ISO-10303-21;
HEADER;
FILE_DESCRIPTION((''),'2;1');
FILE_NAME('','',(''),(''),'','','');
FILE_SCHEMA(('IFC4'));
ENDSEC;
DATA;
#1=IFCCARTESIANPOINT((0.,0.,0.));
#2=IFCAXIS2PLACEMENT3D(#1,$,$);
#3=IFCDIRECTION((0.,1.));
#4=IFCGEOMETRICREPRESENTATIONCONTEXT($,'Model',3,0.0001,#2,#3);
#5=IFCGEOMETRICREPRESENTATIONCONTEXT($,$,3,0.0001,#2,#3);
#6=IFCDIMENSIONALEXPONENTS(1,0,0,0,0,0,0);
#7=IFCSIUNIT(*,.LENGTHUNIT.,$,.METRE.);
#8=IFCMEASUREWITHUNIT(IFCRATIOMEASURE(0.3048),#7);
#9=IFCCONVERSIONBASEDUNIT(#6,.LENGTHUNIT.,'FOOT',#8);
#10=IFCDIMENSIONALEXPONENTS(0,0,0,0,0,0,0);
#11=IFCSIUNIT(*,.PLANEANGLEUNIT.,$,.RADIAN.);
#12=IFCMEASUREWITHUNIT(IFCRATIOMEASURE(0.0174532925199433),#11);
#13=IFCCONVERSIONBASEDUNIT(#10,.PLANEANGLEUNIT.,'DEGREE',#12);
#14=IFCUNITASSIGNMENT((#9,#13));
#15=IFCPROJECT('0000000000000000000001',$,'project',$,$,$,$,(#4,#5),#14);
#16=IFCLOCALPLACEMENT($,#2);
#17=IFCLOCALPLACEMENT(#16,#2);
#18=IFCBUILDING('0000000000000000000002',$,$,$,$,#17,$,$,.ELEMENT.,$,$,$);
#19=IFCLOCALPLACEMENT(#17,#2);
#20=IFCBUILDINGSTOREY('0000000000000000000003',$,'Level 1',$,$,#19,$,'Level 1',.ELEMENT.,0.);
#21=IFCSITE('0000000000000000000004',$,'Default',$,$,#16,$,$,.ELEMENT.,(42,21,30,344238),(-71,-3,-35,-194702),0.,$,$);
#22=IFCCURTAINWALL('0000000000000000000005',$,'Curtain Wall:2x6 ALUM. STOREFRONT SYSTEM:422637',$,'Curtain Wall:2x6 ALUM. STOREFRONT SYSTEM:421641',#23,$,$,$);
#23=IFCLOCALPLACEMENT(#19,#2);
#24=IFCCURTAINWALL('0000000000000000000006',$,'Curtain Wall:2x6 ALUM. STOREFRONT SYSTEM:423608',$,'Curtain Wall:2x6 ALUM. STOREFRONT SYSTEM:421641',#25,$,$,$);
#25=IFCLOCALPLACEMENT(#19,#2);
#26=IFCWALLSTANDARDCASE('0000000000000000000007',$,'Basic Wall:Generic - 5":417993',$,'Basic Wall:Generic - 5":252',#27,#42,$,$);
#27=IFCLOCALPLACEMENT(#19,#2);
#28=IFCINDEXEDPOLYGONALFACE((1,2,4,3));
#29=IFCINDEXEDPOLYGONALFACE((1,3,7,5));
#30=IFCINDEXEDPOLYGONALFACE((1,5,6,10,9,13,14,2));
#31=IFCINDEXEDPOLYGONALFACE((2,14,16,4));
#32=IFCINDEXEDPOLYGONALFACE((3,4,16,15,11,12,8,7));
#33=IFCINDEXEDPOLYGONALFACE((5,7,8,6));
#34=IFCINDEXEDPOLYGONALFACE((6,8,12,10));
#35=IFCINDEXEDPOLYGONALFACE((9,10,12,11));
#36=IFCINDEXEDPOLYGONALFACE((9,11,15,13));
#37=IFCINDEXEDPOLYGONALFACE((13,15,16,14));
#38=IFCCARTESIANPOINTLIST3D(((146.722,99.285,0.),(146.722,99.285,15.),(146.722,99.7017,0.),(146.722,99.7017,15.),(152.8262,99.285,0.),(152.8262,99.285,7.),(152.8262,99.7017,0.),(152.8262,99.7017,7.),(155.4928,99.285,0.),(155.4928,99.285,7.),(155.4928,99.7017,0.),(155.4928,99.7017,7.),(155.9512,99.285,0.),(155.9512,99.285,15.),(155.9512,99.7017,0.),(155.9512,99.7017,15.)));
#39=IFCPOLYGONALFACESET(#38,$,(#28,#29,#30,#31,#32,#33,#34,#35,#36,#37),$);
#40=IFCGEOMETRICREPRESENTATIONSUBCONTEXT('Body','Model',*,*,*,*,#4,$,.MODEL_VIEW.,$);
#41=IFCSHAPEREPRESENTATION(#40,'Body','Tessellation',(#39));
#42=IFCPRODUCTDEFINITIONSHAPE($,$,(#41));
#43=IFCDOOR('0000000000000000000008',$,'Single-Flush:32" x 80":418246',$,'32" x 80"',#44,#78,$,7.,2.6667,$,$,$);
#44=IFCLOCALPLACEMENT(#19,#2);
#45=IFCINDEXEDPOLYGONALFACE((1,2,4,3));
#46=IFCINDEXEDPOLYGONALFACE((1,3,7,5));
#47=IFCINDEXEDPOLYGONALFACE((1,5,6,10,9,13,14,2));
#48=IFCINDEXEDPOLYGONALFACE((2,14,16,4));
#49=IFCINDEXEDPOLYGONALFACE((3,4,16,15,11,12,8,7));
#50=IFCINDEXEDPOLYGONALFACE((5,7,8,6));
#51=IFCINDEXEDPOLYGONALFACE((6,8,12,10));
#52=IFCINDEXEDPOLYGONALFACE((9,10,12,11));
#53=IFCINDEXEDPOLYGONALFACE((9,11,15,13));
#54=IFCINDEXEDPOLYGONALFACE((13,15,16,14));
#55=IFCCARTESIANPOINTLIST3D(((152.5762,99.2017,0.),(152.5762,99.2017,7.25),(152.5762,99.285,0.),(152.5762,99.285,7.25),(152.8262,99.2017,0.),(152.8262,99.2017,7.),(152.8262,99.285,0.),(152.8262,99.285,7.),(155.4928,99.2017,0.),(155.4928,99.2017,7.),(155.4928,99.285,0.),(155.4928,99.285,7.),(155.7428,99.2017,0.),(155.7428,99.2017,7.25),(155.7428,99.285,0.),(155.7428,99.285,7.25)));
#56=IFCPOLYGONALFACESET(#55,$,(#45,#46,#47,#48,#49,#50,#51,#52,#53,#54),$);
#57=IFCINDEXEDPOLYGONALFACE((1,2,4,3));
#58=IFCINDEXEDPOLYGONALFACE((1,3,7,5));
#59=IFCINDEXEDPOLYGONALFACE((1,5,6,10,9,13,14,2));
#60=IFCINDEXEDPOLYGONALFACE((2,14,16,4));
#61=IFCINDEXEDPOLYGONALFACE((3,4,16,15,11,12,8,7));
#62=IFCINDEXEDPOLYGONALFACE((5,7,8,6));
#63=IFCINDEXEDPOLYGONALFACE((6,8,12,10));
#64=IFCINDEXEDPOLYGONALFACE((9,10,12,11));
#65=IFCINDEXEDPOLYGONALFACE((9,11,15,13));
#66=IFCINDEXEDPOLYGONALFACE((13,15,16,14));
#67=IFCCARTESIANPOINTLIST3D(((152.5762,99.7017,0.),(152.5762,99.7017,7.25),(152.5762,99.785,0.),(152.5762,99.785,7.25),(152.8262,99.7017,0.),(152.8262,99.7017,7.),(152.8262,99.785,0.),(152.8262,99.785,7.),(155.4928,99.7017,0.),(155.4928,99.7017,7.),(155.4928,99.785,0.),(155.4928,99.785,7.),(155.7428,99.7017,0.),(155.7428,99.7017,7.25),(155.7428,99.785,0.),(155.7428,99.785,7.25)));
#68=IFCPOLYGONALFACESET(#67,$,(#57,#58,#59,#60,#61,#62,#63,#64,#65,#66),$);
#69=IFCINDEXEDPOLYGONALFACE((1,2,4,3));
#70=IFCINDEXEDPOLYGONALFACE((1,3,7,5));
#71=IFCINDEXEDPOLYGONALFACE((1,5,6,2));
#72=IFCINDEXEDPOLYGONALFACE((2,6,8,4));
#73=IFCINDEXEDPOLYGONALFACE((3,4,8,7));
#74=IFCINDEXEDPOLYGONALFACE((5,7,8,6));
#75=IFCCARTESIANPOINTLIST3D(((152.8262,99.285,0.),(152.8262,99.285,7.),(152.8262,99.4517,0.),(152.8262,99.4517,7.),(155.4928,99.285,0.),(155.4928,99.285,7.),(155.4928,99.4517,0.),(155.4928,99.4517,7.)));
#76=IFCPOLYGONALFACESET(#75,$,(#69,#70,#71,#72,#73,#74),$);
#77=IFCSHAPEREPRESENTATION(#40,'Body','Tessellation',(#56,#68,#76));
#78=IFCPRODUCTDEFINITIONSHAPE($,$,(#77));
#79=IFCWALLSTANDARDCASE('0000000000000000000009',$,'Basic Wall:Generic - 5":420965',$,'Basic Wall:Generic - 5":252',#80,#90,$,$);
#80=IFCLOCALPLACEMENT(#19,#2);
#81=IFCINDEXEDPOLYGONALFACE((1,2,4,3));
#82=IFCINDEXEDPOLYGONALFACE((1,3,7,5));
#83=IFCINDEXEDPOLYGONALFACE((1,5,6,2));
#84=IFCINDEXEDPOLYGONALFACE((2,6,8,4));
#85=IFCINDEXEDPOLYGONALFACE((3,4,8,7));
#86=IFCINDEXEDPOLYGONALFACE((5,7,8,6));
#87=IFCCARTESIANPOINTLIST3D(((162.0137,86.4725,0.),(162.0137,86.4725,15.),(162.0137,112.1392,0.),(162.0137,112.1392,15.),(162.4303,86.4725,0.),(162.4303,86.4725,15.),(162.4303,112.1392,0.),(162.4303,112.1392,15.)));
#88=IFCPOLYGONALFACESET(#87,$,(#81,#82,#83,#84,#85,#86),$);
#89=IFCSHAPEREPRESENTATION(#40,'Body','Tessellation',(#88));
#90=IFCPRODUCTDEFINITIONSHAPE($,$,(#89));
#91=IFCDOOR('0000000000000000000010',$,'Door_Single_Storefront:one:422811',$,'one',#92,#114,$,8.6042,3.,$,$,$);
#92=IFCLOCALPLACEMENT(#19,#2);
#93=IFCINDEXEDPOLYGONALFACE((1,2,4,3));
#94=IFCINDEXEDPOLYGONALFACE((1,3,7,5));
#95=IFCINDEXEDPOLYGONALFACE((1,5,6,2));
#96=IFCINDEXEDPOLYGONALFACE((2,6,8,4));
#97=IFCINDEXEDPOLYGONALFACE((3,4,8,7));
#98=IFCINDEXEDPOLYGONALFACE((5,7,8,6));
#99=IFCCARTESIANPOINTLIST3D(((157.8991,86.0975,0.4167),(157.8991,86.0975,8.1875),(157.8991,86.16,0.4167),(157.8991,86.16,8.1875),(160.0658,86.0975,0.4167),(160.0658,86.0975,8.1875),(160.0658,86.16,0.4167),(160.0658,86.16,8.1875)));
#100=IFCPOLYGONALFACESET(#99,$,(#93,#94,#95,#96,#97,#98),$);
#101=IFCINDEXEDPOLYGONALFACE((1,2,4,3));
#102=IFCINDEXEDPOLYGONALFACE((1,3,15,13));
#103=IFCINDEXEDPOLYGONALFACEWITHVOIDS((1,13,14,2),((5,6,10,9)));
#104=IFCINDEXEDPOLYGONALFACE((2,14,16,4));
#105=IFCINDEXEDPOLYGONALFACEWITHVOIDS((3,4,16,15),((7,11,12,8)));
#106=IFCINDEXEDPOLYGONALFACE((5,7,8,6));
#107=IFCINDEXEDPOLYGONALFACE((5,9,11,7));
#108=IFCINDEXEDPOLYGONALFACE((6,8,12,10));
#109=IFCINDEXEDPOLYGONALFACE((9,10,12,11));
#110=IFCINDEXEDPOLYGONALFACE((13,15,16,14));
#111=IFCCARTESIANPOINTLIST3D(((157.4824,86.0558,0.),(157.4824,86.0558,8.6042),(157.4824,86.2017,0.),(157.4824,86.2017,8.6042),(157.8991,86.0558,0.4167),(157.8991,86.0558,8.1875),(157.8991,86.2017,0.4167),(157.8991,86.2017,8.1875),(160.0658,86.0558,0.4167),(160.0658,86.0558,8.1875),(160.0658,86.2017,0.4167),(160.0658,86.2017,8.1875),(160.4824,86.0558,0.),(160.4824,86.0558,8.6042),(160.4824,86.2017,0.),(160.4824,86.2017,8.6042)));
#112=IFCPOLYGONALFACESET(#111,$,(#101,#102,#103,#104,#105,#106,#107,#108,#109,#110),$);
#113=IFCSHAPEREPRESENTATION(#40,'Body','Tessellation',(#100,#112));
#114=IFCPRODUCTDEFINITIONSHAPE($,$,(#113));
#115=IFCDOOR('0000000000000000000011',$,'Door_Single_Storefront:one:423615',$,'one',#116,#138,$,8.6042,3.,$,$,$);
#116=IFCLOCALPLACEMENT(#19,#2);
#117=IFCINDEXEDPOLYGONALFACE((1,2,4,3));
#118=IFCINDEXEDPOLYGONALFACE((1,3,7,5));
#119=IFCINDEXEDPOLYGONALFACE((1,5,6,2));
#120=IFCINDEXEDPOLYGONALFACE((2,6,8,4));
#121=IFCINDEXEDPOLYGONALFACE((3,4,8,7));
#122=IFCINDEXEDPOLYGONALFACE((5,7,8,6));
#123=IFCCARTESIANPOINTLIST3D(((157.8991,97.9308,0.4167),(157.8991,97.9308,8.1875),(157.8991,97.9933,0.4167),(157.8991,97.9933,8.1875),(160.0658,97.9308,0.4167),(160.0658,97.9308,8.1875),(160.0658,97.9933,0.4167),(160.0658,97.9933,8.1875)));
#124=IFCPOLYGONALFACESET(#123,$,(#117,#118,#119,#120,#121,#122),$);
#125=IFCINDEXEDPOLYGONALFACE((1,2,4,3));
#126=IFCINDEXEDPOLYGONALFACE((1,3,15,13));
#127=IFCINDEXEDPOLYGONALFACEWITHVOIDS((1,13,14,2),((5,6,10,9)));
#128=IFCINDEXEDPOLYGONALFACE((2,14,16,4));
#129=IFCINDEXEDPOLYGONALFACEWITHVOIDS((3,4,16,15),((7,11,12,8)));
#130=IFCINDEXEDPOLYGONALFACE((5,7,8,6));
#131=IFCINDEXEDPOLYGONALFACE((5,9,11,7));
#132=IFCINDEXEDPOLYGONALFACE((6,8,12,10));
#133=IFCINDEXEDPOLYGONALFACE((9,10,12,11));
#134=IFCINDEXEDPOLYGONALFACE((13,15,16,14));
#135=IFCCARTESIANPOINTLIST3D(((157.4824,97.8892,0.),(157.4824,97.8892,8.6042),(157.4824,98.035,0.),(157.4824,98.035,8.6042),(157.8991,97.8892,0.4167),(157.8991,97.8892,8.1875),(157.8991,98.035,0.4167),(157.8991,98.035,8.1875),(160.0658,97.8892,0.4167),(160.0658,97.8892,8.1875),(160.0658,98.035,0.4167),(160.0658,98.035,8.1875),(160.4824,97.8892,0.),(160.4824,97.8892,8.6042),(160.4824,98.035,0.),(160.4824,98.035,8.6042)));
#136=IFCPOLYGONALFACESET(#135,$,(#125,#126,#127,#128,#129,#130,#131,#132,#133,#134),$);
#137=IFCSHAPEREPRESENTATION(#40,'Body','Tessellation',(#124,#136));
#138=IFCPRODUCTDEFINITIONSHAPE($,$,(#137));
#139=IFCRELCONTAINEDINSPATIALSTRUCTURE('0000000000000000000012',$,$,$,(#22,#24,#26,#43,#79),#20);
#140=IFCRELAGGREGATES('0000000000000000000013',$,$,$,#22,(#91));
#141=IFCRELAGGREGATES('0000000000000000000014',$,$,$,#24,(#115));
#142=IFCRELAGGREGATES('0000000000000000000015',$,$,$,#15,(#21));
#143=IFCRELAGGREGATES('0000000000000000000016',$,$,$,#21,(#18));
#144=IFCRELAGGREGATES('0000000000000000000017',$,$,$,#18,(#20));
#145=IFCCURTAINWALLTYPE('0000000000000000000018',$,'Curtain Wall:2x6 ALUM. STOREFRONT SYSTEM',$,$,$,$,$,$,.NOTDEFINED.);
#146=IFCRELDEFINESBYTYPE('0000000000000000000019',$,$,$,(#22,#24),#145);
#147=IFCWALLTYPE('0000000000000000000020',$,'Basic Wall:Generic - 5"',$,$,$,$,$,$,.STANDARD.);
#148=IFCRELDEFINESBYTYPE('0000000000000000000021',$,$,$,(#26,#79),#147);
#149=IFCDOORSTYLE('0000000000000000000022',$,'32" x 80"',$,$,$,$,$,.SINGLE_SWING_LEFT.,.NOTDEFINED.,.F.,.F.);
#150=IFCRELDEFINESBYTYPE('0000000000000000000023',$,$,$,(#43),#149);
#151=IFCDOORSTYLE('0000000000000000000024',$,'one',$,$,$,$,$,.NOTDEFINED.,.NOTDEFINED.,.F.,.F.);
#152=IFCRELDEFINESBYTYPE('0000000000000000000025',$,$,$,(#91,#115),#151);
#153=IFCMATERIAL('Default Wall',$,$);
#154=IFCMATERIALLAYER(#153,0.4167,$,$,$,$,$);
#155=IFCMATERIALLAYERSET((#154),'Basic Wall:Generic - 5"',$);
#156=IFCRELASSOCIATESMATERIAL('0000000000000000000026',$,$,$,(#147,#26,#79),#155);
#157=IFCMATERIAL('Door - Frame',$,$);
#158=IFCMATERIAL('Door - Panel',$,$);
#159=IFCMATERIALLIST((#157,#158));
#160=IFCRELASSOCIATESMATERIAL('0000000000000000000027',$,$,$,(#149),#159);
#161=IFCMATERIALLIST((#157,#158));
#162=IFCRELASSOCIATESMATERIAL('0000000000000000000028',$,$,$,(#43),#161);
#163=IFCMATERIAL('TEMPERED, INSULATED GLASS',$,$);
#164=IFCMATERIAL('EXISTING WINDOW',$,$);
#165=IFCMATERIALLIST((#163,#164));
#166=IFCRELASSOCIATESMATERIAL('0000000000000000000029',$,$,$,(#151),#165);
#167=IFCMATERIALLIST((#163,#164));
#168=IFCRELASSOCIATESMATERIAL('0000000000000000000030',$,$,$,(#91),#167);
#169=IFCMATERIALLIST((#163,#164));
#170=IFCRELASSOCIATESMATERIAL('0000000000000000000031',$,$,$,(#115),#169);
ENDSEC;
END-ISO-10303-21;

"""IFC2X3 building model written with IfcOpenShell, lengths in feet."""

from ifc_helpers import new_model, entity, si_unit, converted_unit, direction, frame, frame_2d, origin, origin_2d_with_axis, place, context, subcontext, project, spatial, polyline, rectangle, outline, extrude, source, transform, mapped, material, material_list, layer, layer_set, layer_usage, type_object, type_shapes, element, fill, aggregate, save


model = new_model("IFC2X3")

# Units and contexts
model_context = context("Model", 3, precision=0.0001, world=origin(), true_north=direction((0.0, 1.0)))
context_of_model = context(None, 3, precision=0.0001, world=origin(), true_north=direction((0.0, 1.0)))
body_context = subcontext(model_context, "Body", "Model", "MODEL_VIEW")
ifc_project = project(units=[converted_unit("LENGTHUNIT", "FOOT", entity("IfcRatioMeasure", 0.3048), si_unit("LENGTHUNIT", "METRE"), dimensions=[1, 0, 0, 0, 0, 0, 0]), converted_unit("PLANEANGLEUNIT", "DEGREE", entity("IfcRatioMeasure", 0.0174532925199433), si_unit("PLANEANGLEUNIT", "RADIAN"), dimensions=[0, 0, 0, 0, 0, 0, 0])], contexts=[model_context, context_of_model])

# Site, building, storey
site_placement = place(None, origin())
site = spatial("IfcSite", under=ifc_project, at=site_placement, Name="Default", CompositionType="ELEMENT", RefLatitude=(42, 21, 30, 344238), RefLongitude=(-71, -3, -35, -194702), RefElevation=0.0)
building_placement = place(site_placement, origin())
building = spatial("IfcBuilding", under=site, at=building_placement, CompositionType="ELEMENT")
storey_placement = place(building_placement, origin())
storey = spatial("IfcBuildingStorey", under=building, at=storey_placement, Name="Level 1", LongName="Level 1", CompositionType="ELEMENT", Elevation=0.0)

# Curtain walls
curtain_wall_type = type_object("IfcCurtainWallType", Name="Curtain Wall:2x6 ALUM. STOREFRONT SYSTEM", PredefinedType="NOTDEFINED")
curtain_wall_1_placement = place(storey_placement, origin())
curtain_wall_1 = element("IfcCurtainWall", 1, at=curtain_wall_1_placement, inside=storey, type_object=curtain_wall_type, Name="Curtain Wall:2x6 ALUM. STOREFRONT SYSTEM:422637", ObjectType="Curtain Wall:2x6 ALUM. STOREFRONT SYSTEM:421641")
curtain_wall_2_placement = place(storey_placement, origin())
curtain_wall_2 = element("IfcCurtainWall", 2, at=curtain_wall_2_placement, inside=storey, type_object=curtain_wall_type, Name="Curtain Wall:2x6 ALUM. STOREFRONT SYSTEM:423608", ObjectType="Curtain Wall:2x6 ALUM. STOREFRONT SYSTEM:421641")

# Shared definitions
ifc_material_1 = material(Name="Default Wall")

# Shared definitions
ifc_layer_1 = layer(ifc_material_1, 0.4167)
ifc_layer_set_1 = layer_set([ifc_layer_1], Name="Basic Wall:Generic - 5\"")
wall_type_1 = type_object("IfcWallType", Name="Basic Wall:Generic - 5\"", PredefinedType="STANDARD", material=ifc_layer_set_1)

# Shared definitions
ifc_material_2 = material(Name="Door - Panel")
ifc_material_3 = material(Name="Door - Frame")

# Wall, opening, door
ifc_layer_usage_1 = layer_usage(ifc_layer_set_1, "AXIS2", "NEGATIVE", 0.2083)
wall_1_placement = place(storey_placement, frame((146.722, 99.4933, 0.0)))
wall_1 = element("IfcWallStandardCase", 3, at=wall_1_placement, inside=storey, type_object=wall_type_1, material=ifc_layer_usage_1, Name="Basic Wall:Generic - 5\":417993", ObjectType="Basic Wall:Generic - 5\":252", context=body_context, shape_type="SweptSolid", body=[
    extrude(rectangle(XDim=9.2292, YDim=0.4167, at=frame_2d((4.6146, 0.0), x_axis=(-1.0, 0.0))), origin(), (0.0, 0.0, 1.0), 15.0),
])
opening_1_placement = place(wall_1_placement, frame((8.7708, 0.2083, 0.0)))
opening_1 = element("IfcOpeningElement", 4, at=opening_1_placement, cuts=wall_1, ObjectType="Opening", context=body_context, shape_type="SweptSolid", body=[
    extrude(rectangle(XDim=2.6667, YDim=7.0, at=frame_2d((3.5, 1.3333), x_axis=(0.0, -1.0))), frame((0.0, 0.0, 0.0), z_axis=(0.0, -1.0, 0.0), x_axis=(0.0, 0.0, 1.0)), (0.0, 0.0, 1.0), 0.4167),
])
ifc_material_list_1 = material_list([ifc_material_3, ifc_material_2])
ifc_material_list_2 = material_list([ifc_material_3, ifc_material_2])
door_style_1 = type_object("IfcDoorStyle", Name="32\" x 80\"", ConstructionType="NOTDEFINED", OperationType="SINGLE_SWING_LEFT", ParameterTakesPrecedence=False, Sizeable=False, material=ifc_material_list_2)
shared_shape_1 = source(origin(), body_context, "Body", "SweptSolid", [
    extrude(outline(polyline([(-1.5833, -3.6875), (1.5833, -3.6875), (1.5833, 3.5625), (1.3333, 3.5625), (1.3333, -3.4375), (-1.3333, -3.4375), (-1.3333, 3.5625), (-1.5833, 3.5625), (-1.5833, -3.6875)])), frame((1.3333, 0.5, 3.5625), z_axis=(0.0, -1.0, 0.0), x_axis=(-1.0, 0.0, 0.0)), (0.0, 0.0, 1.0), 0.0833),
    extrude(outline(polyline([(-3.6875, -1.5833), (3.5625, -1.5833), (3.5625, -1.3333), (-3.4375, -1.3333), (-3.4375, 1.3333), (3.5625, 1.3333), (3.5625, 1.5833), (-3.6875, 1.5833), (-3.6875, -1.5833)])), frame((1.3333, 0.0, 3.5625), z_axis=(0.0, -1.0, 0.0), x_axis=(0.0, 0.0, -1.0)), (0.0, 0.0, 1.0), 0.0833),
    extrude(rectangle(XDim=2.6667, YDim=0.1667, at=origin_2d_with_axis()), frame((1.3333, 0.3333, 0.0)), (0.0, 0.0, 1.0), 7.0),
])
type_shapes(door_style_1, [shared_shape_1])
door_1_placement = place(opening_1_placement, frame((0.0, 0.0, 0.0), z_axis=(0.0, 0.0, 1.0), x_axis=(-1.0, 0.0, 0.0)))
door_1 = element("IfcDoor", 5, at=door_1_placement, inside=storey, type_object=door_style_1, material=ifc_material_list_1, Name="Single-Flush:32\" x 80\":418246", ObjectType="32\" x 80\"", OverallHeight=7.0, OverallWidth=2.6667, context=body_context, shape_type="MappedRepresentation", body=[
    mapped(shared_shape_1, transform((0.0, 0.0, 0.0), scale=1.0)),
])
fill(opening_1, door_1)

# Wall
ifc_layer_usage_2 = layer_usage(ifc_layer_set_1, "AXIS2", "NEGATIVE", 0.2083)
wall_2_placement = place(storey_placement, frame((162.222, 112.1392, 0.0), z_axis=(0.0, 0.0, 1.0), x_axis=(0.0, -1.0, 0.0)))
element("IfcWallStandardCase", 6, at=wall_2_placement, inside=storey, type_object=wall_type_1, material=ifc_layer_usage_2, Name="Basic Wall:Generic - 5\":420965", ObjectType="Basic Wall:Generic - 5\":252", context=body_context, shape_type="SweptSolid", body=[
    extrude(rectangle(XDim=25.6667, YDim=0.4167, at=frame_2d((12.8333, 0.0), x_axis=(-1.0, 0.0))), origin(), (0.0, 0.0, 1.0), 15.0),
])

# Doors
ifc_material_4 = material(Name="TEMPERED, INSULATED GLASS")
ifc_material_5 = material(Name="EXISTING WINDOW")
ifc_material_list_3 = material_list([ifc_material_4, ifc_material_5])
ifc_material_list_4 = material_list([ifc_material_4, ifc_material_5])
door_style_2 = type_object("IfcDoorStyle", Name="one", ConstructionType="NOTDEFINED", OperationType="NOTDEFINED", ParameterTakesPrecedence=False, Sizeable=False, material=ifc_material_list_4)
shared_shape_2 = source(origin(), body_context, "Body", "SweptSolid", [
    extrude(rectangle(XDim=0.0625, YDim=2.1667, at=origin_2d_with_axis()), frame((0.0, 0.0104, 0.4167), z_axis=(0.0, 0.0, 1.0), x_axis=(0.0, 1.0, 0.0)), (0.0, 0.0, 1.0), 7.7708),
    extrude(outline(polyline([(-1.5, -4.3021), (1.5, -4.3021), (1.5, 4.3021), (-1.5, 4.3021), (-1.5, -4.3021)]), holes=[polyline([(1.0833, 3.8854), (1.0833, -3.8854), (-1.0833, -3.8854), (-1.0833, 3.8854), (1.0833, 3.8854)])]), frame((0.0, -0.0625, 4.3021), z_axis=(0.0, 1.0, 0.0), x_axis=(1.0, 0.0, 0.0)), (0.0, 0.0, 1.0), 0.1458),
])
type_shapes(door_style_2, [shared_shape_2])
door_2_placement = place(curtain_wall_1_placement, frame((158.9824, 86.1392, 0.0), z_axis=(0.0, 0.0, 1.0), x_axis=(-1.0, 0.0, 0.0)))
door_2 = element("IfcDoor", 7, at=door_2_placement, type_object=door_style_2, material=ifc_material_list_3, Name="Door_Single_Storefront:one:422811", ObjectType="one", OverallHeight=8.6042, OverallWidth=3.0, context=body_context, shape_type="MappedRepresentation", body=[
    mapped(shared_shape_2, transform((0.0, 0.0, 0.0), scale=1.0)),
])
aggregate(curtain_wall_1, [door_2])
ifc_material_list_5 = material_list([ifc_material_4, ifc_material_5])
door_3_placement = place(curtain_wall_2_placement, frame((158.9824, 97.9725, 0.0), z_axis=(0.0, 0.0, 1.0), x_axis=(-1.0, 0.0, 0.0)))
door_3 = element("IfcDoor", 8, at=door_3_placement, type_object=door_style_2, material=ifc_material_list_5, Name="Door_Single_Storefront:one:423615", ObjectType="one", OverallHeight=8.6042, OverallWidth=3.0, context=body_context, shape_type="MappedRepresentation", body=[
    mapped(shared_shape_2, transform((0.0, 0.0, 0.0), scale=1.0)),
])
aggregate(curtain_wall_2, [door_3])

save(model, "model.ifc")
